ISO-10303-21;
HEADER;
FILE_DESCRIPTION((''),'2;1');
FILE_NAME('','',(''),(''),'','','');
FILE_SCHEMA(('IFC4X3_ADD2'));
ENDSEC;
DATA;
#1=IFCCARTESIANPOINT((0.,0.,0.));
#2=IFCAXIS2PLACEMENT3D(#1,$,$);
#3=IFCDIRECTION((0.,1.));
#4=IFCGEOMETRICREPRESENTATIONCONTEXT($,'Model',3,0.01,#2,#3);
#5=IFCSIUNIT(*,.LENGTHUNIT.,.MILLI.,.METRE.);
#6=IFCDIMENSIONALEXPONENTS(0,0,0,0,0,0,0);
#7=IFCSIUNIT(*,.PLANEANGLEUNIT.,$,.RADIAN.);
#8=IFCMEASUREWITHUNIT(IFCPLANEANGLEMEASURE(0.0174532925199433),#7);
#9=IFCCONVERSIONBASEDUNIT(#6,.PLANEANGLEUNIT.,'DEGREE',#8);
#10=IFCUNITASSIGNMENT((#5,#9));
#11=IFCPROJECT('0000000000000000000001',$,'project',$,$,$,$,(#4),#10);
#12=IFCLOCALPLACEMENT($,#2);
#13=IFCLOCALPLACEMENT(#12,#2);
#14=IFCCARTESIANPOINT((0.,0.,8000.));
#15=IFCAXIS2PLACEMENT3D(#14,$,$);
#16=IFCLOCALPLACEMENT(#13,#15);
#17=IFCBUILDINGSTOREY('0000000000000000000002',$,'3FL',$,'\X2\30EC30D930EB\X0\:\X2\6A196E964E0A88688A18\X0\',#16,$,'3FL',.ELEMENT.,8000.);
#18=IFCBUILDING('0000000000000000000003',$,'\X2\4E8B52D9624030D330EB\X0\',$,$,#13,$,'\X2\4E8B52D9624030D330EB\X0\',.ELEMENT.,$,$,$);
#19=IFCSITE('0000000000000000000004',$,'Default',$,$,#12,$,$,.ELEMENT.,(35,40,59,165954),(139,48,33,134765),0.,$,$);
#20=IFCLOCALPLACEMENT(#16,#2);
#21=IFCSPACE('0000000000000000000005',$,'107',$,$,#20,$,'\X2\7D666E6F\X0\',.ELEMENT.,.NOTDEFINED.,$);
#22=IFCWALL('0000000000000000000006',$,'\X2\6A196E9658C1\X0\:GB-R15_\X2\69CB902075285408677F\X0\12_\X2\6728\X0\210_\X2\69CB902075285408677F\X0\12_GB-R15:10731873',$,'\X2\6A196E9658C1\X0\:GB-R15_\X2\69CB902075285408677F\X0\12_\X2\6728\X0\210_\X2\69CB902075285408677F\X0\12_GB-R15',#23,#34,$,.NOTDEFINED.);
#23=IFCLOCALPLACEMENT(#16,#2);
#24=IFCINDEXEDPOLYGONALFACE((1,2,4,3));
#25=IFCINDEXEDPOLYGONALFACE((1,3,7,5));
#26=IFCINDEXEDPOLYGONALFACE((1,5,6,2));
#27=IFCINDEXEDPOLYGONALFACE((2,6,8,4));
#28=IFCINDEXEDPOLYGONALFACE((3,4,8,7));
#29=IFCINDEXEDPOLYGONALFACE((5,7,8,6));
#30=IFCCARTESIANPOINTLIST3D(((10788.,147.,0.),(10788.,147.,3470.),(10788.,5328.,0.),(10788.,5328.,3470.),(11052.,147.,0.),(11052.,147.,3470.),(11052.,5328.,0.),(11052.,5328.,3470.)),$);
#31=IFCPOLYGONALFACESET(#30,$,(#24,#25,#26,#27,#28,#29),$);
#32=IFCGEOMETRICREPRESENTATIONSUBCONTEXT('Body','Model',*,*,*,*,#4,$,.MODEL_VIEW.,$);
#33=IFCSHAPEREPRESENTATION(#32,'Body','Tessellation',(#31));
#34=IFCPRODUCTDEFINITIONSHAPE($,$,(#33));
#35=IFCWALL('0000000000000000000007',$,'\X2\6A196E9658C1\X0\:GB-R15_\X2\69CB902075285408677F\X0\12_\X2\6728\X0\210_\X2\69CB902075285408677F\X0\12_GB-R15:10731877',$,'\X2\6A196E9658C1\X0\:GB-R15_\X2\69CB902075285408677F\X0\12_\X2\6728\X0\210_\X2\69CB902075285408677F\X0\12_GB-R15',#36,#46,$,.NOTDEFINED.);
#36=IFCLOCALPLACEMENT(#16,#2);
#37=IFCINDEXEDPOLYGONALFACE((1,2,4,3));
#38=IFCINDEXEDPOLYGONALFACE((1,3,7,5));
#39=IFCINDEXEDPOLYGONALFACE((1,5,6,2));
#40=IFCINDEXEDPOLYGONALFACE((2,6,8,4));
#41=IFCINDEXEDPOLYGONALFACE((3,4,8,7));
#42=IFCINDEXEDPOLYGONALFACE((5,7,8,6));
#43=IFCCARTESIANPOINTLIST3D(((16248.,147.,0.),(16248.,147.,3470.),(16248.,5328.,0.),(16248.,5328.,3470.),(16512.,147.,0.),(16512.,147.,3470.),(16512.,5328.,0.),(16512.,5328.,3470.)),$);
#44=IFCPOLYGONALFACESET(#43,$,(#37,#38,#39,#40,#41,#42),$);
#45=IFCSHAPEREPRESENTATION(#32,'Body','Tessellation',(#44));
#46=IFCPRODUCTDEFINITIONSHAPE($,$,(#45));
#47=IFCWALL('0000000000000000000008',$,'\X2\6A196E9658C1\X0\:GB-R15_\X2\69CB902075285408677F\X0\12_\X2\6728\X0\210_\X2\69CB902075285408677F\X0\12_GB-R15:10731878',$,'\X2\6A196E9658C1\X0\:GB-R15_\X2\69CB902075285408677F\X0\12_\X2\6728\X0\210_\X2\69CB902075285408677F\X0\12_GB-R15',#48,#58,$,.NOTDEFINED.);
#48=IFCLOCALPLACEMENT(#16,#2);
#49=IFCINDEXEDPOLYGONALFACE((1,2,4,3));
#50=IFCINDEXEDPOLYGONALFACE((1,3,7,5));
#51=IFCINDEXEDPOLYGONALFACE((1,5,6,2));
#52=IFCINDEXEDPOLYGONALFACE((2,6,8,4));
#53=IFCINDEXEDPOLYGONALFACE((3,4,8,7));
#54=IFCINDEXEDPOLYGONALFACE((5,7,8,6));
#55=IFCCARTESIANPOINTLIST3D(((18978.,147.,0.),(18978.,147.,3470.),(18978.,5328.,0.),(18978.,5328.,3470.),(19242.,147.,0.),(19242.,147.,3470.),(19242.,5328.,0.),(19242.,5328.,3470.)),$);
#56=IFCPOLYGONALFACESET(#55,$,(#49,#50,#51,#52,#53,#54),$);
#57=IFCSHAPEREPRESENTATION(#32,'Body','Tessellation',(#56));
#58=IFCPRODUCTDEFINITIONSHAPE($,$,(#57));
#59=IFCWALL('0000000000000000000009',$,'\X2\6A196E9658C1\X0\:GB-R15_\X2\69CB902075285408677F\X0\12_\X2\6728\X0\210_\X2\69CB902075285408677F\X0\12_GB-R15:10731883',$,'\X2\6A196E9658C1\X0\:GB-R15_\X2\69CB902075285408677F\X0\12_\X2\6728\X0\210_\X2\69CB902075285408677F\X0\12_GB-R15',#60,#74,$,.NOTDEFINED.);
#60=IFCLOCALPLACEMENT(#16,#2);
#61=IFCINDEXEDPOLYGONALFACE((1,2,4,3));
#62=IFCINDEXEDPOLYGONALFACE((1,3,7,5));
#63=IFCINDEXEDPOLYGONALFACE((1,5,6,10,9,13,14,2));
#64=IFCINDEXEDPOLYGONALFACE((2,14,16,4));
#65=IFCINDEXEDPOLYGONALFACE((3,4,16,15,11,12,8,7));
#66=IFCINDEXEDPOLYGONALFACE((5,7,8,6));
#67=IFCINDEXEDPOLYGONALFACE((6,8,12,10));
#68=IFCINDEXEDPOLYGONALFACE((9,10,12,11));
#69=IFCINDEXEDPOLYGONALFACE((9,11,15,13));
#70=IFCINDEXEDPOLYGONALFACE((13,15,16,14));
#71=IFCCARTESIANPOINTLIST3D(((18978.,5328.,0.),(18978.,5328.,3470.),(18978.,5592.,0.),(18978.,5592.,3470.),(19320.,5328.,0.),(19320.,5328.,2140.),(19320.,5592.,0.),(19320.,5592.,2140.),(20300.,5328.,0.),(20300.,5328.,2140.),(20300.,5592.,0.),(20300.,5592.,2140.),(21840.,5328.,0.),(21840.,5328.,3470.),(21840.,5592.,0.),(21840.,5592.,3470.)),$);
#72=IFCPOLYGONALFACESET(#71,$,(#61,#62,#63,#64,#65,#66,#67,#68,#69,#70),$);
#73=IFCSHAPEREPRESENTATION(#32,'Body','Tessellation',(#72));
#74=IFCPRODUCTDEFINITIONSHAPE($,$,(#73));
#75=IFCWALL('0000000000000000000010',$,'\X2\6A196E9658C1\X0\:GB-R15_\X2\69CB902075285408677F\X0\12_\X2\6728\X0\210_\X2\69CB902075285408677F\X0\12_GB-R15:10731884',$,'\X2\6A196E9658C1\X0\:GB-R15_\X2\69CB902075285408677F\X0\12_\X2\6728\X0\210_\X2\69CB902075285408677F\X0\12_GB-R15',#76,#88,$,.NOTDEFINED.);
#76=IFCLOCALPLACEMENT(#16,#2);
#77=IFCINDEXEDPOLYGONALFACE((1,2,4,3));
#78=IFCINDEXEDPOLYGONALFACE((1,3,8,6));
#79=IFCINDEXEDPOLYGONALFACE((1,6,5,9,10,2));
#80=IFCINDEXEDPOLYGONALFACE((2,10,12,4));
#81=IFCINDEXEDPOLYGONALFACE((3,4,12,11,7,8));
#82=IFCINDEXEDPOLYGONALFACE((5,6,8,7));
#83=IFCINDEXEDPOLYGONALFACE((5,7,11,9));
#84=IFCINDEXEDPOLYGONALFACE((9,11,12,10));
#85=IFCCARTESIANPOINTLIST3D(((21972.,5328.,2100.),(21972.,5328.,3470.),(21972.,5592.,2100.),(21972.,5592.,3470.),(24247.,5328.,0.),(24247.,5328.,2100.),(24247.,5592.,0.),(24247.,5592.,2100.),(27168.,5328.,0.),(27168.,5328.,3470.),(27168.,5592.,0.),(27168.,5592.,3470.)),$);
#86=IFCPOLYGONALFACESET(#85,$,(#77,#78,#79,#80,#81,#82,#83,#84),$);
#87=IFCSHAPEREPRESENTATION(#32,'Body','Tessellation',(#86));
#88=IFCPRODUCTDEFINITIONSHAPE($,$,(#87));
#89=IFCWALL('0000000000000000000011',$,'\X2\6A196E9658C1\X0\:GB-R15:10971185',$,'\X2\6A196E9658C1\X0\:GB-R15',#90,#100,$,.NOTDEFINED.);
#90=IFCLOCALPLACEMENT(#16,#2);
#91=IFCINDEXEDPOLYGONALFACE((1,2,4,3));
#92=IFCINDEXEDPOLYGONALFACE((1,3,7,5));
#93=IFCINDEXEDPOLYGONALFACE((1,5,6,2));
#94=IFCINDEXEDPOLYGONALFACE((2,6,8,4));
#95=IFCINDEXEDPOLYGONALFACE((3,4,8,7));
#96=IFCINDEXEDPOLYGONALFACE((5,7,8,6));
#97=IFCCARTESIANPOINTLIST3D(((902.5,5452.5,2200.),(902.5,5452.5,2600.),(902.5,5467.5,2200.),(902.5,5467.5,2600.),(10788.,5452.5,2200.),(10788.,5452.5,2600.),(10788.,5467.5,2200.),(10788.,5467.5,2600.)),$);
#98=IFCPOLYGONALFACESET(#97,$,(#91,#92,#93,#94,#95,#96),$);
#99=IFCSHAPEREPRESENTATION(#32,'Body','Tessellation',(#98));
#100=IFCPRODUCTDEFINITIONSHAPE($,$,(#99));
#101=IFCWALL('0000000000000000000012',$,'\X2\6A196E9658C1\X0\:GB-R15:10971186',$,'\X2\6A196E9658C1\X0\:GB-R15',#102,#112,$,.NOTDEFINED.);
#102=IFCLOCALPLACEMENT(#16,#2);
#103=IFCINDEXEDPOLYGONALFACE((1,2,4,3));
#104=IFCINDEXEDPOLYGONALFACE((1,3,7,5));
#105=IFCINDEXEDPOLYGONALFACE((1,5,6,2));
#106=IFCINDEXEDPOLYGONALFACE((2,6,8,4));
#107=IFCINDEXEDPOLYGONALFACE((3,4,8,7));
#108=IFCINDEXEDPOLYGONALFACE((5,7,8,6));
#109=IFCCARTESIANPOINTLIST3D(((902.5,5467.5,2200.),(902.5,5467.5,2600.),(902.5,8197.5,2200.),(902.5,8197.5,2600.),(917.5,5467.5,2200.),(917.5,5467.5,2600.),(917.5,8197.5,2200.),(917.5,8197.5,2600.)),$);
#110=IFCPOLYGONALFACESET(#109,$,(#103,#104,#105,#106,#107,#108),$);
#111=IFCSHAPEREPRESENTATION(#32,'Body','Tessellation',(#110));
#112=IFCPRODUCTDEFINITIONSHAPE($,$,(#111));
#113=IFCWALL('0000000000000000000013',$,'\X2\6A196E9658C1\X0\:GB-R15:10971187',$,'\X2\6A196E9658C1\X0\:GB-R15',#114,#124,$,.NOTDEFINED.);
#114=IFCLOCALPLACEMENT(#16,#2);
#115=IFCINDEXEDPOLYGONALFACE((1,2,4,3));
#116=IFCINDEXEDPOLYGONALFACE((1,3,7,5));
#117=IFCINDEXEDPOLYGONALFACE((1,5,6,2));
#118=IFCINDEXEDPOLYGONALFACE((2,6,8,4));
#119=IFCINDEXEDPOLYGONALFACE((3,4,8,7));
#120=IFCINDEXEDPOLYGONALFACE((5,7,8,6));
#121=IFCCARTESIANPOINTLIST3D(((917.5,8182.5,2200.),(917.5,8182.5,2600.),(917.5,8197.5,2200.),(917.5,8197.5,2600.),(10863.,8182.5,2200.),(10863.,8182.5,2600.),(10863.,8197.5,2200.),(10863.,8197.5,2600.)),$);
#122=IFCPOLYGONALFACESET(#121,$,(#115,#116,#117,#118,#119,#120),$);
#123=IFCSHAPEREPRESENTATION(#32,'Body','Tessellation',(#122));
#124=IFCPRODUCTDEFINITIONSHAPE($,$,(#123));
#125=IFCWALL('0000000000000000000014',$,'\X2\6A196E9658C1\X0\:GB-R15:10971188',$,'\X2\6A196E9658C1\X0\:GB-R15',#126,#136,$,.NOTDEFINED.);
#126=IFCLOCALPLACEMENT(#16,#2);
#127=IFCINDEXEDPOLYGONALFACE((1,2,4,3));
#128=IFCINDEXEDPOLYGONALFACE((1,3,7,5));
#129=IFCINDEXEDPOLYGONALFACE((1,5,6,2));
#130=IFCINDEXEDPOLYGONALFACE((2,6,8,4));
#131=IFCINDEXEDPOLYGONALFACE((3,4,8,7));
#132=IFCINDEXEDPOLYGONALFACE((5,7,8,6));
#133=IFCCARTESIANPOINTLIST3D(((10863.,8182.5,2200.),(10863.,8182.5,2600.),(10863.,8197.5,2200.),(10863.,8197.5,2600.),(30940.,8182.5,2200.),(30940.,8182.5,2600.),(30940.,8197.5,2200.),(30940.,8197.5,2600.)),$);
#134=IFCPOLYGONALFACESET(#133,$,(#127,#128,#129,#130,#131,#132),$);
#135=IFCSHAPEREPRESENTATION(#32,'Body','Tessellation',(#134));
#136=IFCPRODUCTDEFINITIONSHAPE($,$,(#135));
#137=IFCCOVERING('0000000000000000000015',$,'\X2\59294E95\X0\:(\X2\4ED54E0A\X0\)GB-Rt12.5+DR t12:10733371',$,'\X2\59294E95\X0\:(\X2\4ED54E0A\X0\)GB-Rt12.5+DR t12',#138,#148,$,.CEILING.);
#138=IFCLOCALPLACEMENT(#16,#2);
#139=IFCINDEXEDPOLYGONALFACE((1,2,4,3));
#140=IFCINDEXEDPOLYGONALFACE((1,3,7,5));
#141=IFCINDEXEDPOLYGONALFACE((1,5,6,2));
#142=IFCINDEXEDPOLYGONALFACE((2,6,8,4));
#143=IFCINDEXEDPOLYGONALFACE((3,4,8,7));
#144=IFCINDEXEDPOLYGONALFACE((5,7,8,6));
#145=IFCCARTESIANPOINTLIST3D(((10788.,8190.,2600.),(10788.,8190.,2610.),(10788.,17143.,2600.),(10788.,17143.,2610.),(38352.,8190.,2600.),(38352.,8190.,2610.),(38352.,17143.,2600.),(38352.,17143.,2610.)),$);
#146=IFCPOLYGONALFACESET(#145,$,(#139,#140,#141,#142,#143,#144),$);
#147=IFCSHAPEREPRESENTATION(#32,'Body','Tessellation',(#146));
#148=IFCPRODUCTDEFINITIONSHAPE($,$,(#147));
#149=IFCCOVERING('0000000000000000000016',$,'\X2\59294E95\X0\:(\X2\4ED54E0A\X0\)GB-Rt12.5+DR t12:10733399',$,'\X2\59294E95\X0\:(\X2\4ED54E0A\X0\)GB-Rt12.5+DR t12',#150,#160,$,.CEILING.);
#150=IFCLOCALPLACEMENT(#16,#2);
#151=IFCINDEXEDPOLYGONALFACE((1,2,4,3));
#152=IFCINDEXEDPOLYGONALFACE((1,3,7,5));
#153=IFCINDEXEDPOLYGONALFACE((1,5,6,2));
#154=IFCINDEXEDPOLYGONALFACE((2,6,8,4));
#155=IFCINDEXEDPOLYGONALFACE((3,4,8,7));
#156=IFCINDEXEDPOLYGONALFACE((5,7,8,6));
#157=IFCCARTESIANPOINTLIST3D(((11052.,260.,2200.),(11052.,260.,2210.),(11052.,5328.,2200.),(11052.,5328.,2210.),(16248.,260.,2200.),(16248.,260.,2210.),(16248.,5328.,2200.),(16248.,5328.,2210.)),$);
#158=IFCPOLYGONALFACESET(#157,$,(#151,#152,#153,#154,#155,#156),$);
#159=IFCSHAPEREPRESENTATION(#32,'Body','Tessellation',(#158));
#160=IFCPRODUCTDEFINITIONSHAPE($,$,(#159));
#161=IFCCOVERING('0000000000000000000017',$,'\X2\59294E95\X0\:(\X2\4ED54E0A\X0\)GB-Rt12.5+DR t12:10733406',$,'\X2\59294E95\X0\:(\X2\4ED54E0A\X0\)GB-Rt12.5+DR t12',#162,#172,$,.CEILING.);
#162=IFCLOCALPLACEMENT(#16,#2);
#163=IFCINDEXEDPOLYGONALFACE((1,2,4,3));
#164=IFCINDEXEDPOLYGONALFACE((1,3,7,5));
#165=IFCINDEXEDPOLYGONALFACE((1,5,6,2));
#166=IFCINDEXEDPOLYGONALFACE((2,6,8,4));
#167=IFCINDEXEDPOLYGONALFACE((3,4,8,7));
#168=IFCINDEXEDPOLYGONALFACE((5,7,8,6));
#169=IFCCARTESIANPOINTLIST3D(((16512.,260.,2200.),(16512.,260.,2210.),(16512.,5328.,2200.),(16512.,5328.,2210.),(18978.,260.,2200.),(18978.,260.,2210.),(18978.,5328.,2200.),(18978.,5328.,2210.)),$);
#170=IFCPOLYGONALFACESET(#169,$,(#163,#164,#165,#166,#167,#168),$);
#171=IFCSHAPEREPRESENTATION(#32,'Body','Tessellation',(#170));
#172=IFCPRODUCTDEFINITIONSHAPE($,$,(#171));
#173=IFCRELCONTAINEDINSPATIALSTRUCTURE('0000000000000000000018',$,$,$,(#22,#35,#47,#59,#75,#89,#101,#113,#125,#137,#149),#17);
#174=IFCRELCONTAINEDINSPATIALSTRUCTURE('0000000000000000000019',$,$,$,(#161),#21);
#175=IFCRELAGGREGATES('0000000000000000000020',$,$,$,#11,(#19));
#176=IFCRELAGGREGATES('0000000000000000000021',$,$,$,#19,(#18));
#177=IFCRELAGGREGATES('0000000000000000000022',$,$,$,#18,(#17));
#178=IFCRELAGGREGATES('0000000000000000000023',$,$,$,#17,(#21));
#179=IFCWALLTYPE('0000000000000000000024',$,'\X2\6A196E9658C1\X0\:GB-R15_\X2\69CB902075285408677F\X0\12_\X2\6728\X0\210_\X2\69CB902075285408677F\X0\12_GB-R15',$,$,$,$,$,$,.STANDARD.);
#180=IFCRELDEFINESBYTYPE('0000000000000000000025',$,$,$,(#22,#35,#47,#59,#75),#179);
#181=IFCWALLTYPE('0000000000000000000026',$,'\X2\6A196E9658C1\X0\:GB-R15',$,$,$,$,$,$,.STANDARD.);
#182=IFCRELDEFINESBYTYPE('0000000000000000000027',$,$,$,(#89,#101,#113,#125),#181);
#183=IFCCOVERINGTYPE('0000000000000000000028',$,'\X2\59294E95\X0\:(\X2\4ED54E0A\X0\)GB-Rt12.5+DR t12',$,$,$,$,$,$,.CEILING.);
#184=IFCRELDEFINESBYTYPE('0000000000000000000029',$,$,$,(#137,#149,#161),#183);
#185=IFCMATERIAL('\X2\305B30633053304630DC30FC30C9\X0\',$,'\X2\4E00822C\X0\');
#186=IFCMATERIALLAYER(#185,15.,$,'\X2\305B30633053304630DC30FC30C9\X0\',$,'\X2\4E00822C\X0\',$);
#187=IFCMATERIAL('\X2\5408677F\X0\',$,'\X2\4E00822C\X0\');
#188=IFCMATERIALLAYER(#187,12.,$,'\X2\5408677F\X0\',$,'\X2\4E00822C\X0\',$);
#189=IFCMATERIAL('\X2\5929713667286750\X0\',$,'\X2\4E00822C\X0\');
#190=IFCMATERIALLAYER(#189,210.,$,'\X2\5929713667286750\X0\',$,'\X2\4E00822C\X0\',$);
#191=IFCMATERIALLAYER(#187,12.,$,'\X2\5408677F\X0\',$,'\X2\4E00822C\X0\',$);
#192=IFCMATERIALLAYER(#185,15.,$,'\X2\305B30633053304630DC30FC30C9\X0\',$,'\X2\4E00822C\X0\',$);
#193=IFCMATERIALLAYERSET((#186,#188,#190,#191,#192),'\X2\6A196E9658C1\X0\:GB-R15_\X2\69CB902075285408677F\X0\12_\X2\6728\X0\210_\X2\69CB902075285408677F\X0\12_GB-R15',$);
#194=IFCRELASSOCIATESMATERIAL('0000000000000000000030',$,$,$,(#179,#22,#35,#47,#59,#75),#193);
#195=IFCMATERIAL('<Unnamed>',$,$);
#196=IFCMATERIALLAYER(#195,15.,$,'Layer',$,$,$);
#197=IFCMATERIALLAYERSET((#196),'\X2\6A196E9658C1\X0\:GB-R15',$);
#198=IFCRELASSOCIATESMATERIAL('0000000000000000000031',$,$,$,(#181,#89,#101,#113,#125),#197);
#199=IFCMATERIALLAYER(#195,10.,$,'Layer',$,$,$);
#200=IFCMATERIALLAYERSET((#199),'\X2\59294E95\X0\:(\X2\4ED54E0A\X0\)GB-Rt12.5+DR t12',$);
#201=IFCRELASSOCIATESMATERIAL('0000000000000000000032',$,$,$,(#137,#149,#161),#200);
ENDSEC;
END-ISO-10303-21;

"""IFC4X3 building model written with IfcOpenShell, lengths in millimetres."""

from ifc_helpers import new_model, entity, si_unit, converted_unit, direction, frame, frame_2d, origin, origin_2d_with_axis, place, context, subcontext, project, spatial, rectangle, extrude, material, layer, layer_set, layer_usage, type_object, element, save


model = new_model("IFC4X3")

# Units and contexts
model_context = context("Model", 3, precision=0.01, world=origin(), true_north=direction((0.0, 1.0)))
body_context = subcontext(model_context, "Body", "Model", "MODEL_VIEW")
ifc_project = project(units=[si_unit("LENGTHUNIT", "METRE", prefix="MILLI"), converted_unit("PLANEANGLEUNIT", "DEGREE", entity("IfcPlaneAngleMeasure", 0.0174532925199433), si_unit("PLANEANGLEUNIT", "RADIAN"), dimensions=[0, 0, 0, 0, 0, 0, 0])], contexts=[model_context])

# Site, building, storey
site_placement = place(None, origin())
site = spatial("IfcSite", under=ifc_project, at=site_placement, Name="Default", CompositionType="ELEMENT", RefLatitude=(35, 40, 59, 165954), RefLongitude=(139, 48, 33, 134765), RefElevation=0.0)
building_placement = place(site_placement, origin())
building = spatial("IfcBuilding", under=site, at=building_placement, Name="事務所ビル", LongName="事務所ビル", CompositionType="ELEMENT")
storey_placement = place(building_placement, frame((0.0, 0.0, 8000.0)))
storey = spatial("IfcBuildingStorey", under=building, at=storey_placement, Name="3FL", ObjectType="レベル:標準上表記", LongName="3FL", CompositionType="ELEMENT", Elevation=8000.0)

# Shared definitions
ifc_material_1 = material(Name="<Unnamed>")
ifc_material_2 = material(Name="合板", Category="一般")

# Wall
ifc_material_3 = material(Name="せっこうボード", Category="一般")
ifc_layer_1 = layer(ifc_material_3, 15.0, Name="せっこうボード", Category="一般")
ifc_layer_2 = layer(ifc_material_2, 12.0, Name="合板", Category="一般")
ifc_material_4 = material(Name="天然木材", Category="一般")
ifc_layer_3 = layer(ifc_material_4, 210.0, Name="天然木材", Category="一般")
ifc_layer_4 = layer(ifc_material_2, 12.0, Name="合板", Category="一般")
ifc_layer_5 = layer(ifc_material_3, 15.0, Name="せっこうボード", Category="一般")
ifc_layer_set_1 = layer_set([ifc_layer_1, ifc_layer_2, ifc_layer_3, ifc_layer_4, ifc_layer_5], Name="標準壁:GB-R15_構造用合板12_木210_構造用合板12_GB-R15")
wall_type_1 = type_object("IfcWallType", Name="標準壁:GB-R15_構造用合板12_木210_構造用合板12_GB-R15", PredefinedType="STANDARD", material=ifc_layer_set_1)
wall_1_placement = place(storey_placement, frame((10920.0, 147.0, 0.0), z_axis=(0.0, 0.0, 1.0), x_axis=(0.0, 1.0, 0.0)))
element("IfcWall", 1, at=wall_1_placement, inside=storey, type_object=wall_type_1, material=ifc_layer_set_1, Name="標準壁:GB-R15_構造用合板12_木210_構造用合板12_GB-R15:10731873", ObjectType="標準壁:GB-R15_構造用合板12_木210_構造用合板12_GB-R15", PredefinedType="NOTDEFINED", context=body_context, shape_type="SweptSolid", body=[
    extrude(rectangle(XDim=5181.0, YDim=264.0, at=frame_2d((2590.5, 0.0), x_axis=(-1.0, 0.0))), origin(), (0.0, 0.0, 1.0), 3470.0),
])

# Walls
wall_2_placement = place(storey_placement, frame((16380.0, 147.0, 0.0), z_axis=(0.0, 0.0, 1.0), x_axis=(0.0, 1.0, 0.0)))
element("IfcWall", 2, at=wall_2_placement, inside=storey, type_object=wall_type_1, material=ifc_layer_set_1, Name="標準壁:GB-R15_構造用合板12_木210_構造用合板12_GB-R15:10731877", ObjectType="標準壁:GB-R15_構造用合板12_木210_構造用合板12_GB-R15", PredefinedType="NOTDEFINED", context=body_context, shape_type="SweptSolid", body=[
    extrude(rectangle(XDim=5181.0, YDim=264.0, at=frame_2d((2590.5, 0.0), x_axis=(-1.0, 0.0))), origin(), (0.0, 0.0, 1.0), 3470.0),
])
wall_3_placement = place(storey_placement, frame((19110.0, 147.0, 0.0), z_axis=(0.0, 0.0, 1.0), x_axis=(0.0, 1.0, 0.0)))
element("IfcWall", 3, at=wall_3_placement, inside=storey, type_object=wall_type_1, material=ifc_layer_set_1, Name="標準壁:GB-R15_構造用合板12_木210_構造用合板12_GB-R15:10731878", ObjectType="標準壁:GB-R15_構造用合板12_木210_構造用合板12_GB-R15", PredefinedType="NOTDEFINED", context=body_context, shape_type="SweptSolid", body=[
    extrude(rectangle(XDim=5181.0, YDim=264.0, at=frame_2d((2590.5, 0.0), x_axis=(-1.0, 0.0))), origin(), (0.0, 0.0, 1.0), 3470.0),
])

# Walls, openings
wall_4_placement = place(storey_placement, frame((18978.0, 5460.0, 0.0)))
wall_4 = element("IfcWall", 4, at=wall_4_placement, inside=storey, type_object=wall_type_1, material=ifc_layer_set_1, Name="標準壁:GB-R15_構造用合板12_木210_構造用合板12_GB-R15:10731883", ObjectType="標準壁:GB-R15_構造用合板12_木210_構造用合板12_GB-R15", PredefinedType="NOTDEFINED", context=body_context, shape_type="SweptSolid", body=[
    extrude(rectangle(XDim=2862.0, YDim=264.0, at=frame_2d((1431.0, 0.0), x_axis=(-1.0, 0.0))), origin(), (0.0, 0.0, 1.0), 3470.0),
])
opening_1_placement = place(wall_4_placement, frame((342.0, -132.0, 0.0)))
element("IfcOpeningElement", 5, at=opening_1_placement, cuts=wall_4, PredefinedType="OPENING", context=body_context, shape_type="SweptSolid", body=[
    extrude(rectangle(XDim=2140.0, YDim=980.0, at=frame_2d((1070.0, 490.0), x_axis=(-1.0, 0.0))), frame((0.0, 0.0, 0.0), z_axis=(0.0, 1.0, 0.0), x_axis=(0.0, 0.0, 1.0)), (0.0, 0.0, 1.0), 264.0),
])
wall_5_placement = place(storey_placement, frame((21972.0, 5460.0, 0.0)))
wall_5 = element("IfcWall", 6, at=wall_5_placement, inside=storey, type_object=wall_type_1, material=ifc_layer_set_1, Name="標準壁:GB-R15_構造用合板12_木210_構造用合板12_GB-R15:10731884", ObjectType="標準壁:GB-R15_構造用合板12_木210_構造用合板12_GB-R15", PredefinedType="NOTDEFINED", context=body_context, shape_type="SweptSolid", body=[
    extrude(rectangle(XDim=5196.0, YDim=264.0, at=frame_2d((2598.0, 0.0), x_axis=(-1.0, 0.0))), origin(), (0.0, 0.0, 1.0), 3470.0),
])
opening_2_placement = place(wall_5_placement, frame((0.0, -132.0, 0.0)))
element("IfcOpeningElement", 7, at=opening_2_placement, cuts=wall_5, PredefinedType="OPENING", context=body_context, shape_type="SweptSolid", body=[
    extrude(rectangle(XDim=2100.0, YDim=2275.0, at=frame_2d((1050.0, 1137.5), x_axis=(-1.0, 0.0))), frame((0.0, 0.0, 0.0), z_axis=(0.0, 1.0, 0.0), x_axis=(0.0, 0.0, 1.0)), (0.0, 0.0, 1.0), 264.0),
])

# Walls
ifc_layer_6 = layer(ifc_material_1, 15.0, Name="Layer")
ifc_layer_set_2 = layer_set([ifc_layer_6], Name="標準壁:GB-R15")
wall_type_2 = type_object("IfcWallType", Name="標準壁:GB-R15", PredefinedType="STANDARD", material=ifc_layer_set_2)
wall_6_placement = place(storey_placement, frame((10788.0, 5460.0, 2200.0), z_axis=(0.0, 0.0, 1.0), x_axis=(-1.0, 0.0, 0.0)))
element("IfcWall", 8, at=wall_6_placement, inside=storey, type_object=wall_type_2, material=ifc_layer_set_2, Name="標準壁:GB-R15:10971185", ObjectType="標準壁:GB-R15", PredefinedType="NOTDEFINED", context=body_context, shape_type="SweptSolid", body=[
    extrude(rectangle(XDim=9885.5, YDim=15.0, at=frame_2d((4942.8, 0.0), x_axis=(-1.0, 0.0))), origin(), (0.0, 0.0, 1.0), 400.0),
])
wall_7_placement = place(storey_placement, frame((910.0, 5467.5, 2200.0), z_axis=(0.0, 0.0, 1.0), x_axis=(0.0, 1.0, 0.0)))
element("IfcWall", 9, at=wall_7_placement, inside=storey, type_object=wall_type_2, material=ifc_layer_set_2, Name="標準壁:GB-R15:10971186", ObjectType="標準壁:GB-R15", PredefinedType="NOTDEFINED", context=body_context, shape_type="SweptSolid", body=[
    extrude(rectangle(XDim=2730.0, YDim=15.0, at=frame_2d((1365.0, 0.0), x_axis=(-1.0, 0.0))), origin(), (0.0, 0.0, 1.0), 400.0),
])
wall_8_placement = place(storey_placement, frame((917.5, 8190.0, 2200.0)))
element("IfcWall", 10, at=wall_8_placement, inside=storey, type_object=wall_type_2, material=ifc_layer_set_2, Name="標準壁:GB-R15:10971187", ObjectType="標準壁:GB-R15", PredefinedType="NOTDEFINED", context=body_context, shape_type="SweptSolid", body=[
    extrude(rectangle(XDim=9945.5, YDim=15.0, at=frame_2d((4972.8, 0.0), x_axis=(-1.0, 0.0))), origin(), (0.0, 0.0, 1.0), 400.0),
])
wall_9_placement = place(storey_placement, frame((10863.0, 8190.0, 2200.0)))
element("IfcWall", 11, at=wall_9_placement, inside=storey, type_object=wall_type_2, material=ifc_layer_set_2, Name="標準壁:GB-R15:10971188", ObjectType="標準壁:GB-R15", PredefinedType="NOTDEFINED", context=body_context, shape_type="SweptSolid", body=[
    extrude(rectangle(XDim=20077.0, YDim=15.0, at=frame_2d((10038.5, 0.0), x_axis=(-1.0, 0.0))), origin(), (0.0, 0.0, 1.0), 400.0),
])

# Coverings
ifc_layer_7 = layer(ifc_material_1, 10.0, Name="Layer")
ifc_layer_set_3 = layer_set([ifc_layer_7], Name="天井:(仕上)GB-Rt12.5+DR t12")
covering_type = type_object("IfcCoveringType", Name="天井:(仕上)GB-Rt12.5+DR t12", PredefinedType="CEILING")
ifc_layer_usage_1 = layer_usage(ifc_layer_set_3, "AXIS3", "NEGATIVE", 0.0)
covering_1_placement = place(storey_placement, frame((10788.0, 8190.0, 2600.0)))
element("IfcCovering", 12, at=covering_1_placement, inside=storey, type_object=covering_type, material=ifc_layer_usage_1, Name="天井:(仕上)GB-Rt12.5+DR t12:10733371", ObjectType="天井:(仕上)GB-Rt12.5+DR t12", PredefinedType="CEILING", context=body_context, shape_type="SweptSolid", body=[
    extrude(rectangle(XDim=8953.0, YDim=27564.0, at=frame_2d((0.0, 0.0), x_axis=(1.0, 0.0))), frame((13782.0, 4476.5, 0.0), z_axis=(0.0, 0.0, 1.0), x_axis=(0.0, 1.0, 0.0)), (0.0, 0.0, 1.0), 10.0),
])
ifc_layer_usage_2 = layer_usage(ifc_layer_set_3, "AXIS3", "NEGATIVE", 0.0)
covering_2_placement = place(storey_placement, frame((11052.0, 260.0, 2200.0)))
element("IfcCovering", 13, at=covering_2_placement, inside=storey, type_object=covering_type, material=ifc_layer_usage_2, Name="天井:(仕上)GB-Rt12.5+DR t12:10733399", ObjectType="天井:(仕上)GB-Rt12.5+DR t12", PredefinedType="CEILING", context=body_context, shape_type="SweptSolid", body=[
    extrude(rectangle(XDim=5196.0, YDim=5068.0, at=origin_2d_with_axis()), frame((2598.0, 2534.0, 0.0), z_axis=(0.0, 0.0, 1.0), x_axis=(-1.0, 0.0, 0.0)), (0.0, 0.0, 1.0), 10.0),
])

# Shared definitions
space_placement = place(storey_placement, origin())
space = spatial("IfcSpace", under=storey, at=space_placement, Name="107", LongName="給湯", CompositionType="ELEMENT", PredefinedType="NOTDEFINED")

# Covering
ifc_layer_usage_3 = layer_usage(ifc_layer_set_3, "AXIS3", "NEGATIVE", 0.0)
covering_3_placement = place(space_placement, frame((16512.0, 260.0, 2200.0)))
element("IfcCovering", 14, at=covering_3_placement, inside=space, type_object=covering_type, material=ifc_layer_usage_3, Name="天井:(仕上)GB-Rt12.5+DR t12:10733406", ObjectType="天井:(仕上)GB-Rt12.5+DR t12", PredefinedType="CEILING", context=body_context, shape_type="SweptSolid", body=[
    extrude(rectangle(XDim=2466.0, YDim=5068.0, at=frame_2d((0.0, 0.0), x_axis=(1.0, 0.0))), frame((1233.0, 2534.0, 0.0), z_axis=(0.0, 0.0, 1.0), x_axis=(-1.0, 0.0, 0.0)), (0.0, 0.0, 1.0), 10.0),
])

save(model, "model.ifc")
